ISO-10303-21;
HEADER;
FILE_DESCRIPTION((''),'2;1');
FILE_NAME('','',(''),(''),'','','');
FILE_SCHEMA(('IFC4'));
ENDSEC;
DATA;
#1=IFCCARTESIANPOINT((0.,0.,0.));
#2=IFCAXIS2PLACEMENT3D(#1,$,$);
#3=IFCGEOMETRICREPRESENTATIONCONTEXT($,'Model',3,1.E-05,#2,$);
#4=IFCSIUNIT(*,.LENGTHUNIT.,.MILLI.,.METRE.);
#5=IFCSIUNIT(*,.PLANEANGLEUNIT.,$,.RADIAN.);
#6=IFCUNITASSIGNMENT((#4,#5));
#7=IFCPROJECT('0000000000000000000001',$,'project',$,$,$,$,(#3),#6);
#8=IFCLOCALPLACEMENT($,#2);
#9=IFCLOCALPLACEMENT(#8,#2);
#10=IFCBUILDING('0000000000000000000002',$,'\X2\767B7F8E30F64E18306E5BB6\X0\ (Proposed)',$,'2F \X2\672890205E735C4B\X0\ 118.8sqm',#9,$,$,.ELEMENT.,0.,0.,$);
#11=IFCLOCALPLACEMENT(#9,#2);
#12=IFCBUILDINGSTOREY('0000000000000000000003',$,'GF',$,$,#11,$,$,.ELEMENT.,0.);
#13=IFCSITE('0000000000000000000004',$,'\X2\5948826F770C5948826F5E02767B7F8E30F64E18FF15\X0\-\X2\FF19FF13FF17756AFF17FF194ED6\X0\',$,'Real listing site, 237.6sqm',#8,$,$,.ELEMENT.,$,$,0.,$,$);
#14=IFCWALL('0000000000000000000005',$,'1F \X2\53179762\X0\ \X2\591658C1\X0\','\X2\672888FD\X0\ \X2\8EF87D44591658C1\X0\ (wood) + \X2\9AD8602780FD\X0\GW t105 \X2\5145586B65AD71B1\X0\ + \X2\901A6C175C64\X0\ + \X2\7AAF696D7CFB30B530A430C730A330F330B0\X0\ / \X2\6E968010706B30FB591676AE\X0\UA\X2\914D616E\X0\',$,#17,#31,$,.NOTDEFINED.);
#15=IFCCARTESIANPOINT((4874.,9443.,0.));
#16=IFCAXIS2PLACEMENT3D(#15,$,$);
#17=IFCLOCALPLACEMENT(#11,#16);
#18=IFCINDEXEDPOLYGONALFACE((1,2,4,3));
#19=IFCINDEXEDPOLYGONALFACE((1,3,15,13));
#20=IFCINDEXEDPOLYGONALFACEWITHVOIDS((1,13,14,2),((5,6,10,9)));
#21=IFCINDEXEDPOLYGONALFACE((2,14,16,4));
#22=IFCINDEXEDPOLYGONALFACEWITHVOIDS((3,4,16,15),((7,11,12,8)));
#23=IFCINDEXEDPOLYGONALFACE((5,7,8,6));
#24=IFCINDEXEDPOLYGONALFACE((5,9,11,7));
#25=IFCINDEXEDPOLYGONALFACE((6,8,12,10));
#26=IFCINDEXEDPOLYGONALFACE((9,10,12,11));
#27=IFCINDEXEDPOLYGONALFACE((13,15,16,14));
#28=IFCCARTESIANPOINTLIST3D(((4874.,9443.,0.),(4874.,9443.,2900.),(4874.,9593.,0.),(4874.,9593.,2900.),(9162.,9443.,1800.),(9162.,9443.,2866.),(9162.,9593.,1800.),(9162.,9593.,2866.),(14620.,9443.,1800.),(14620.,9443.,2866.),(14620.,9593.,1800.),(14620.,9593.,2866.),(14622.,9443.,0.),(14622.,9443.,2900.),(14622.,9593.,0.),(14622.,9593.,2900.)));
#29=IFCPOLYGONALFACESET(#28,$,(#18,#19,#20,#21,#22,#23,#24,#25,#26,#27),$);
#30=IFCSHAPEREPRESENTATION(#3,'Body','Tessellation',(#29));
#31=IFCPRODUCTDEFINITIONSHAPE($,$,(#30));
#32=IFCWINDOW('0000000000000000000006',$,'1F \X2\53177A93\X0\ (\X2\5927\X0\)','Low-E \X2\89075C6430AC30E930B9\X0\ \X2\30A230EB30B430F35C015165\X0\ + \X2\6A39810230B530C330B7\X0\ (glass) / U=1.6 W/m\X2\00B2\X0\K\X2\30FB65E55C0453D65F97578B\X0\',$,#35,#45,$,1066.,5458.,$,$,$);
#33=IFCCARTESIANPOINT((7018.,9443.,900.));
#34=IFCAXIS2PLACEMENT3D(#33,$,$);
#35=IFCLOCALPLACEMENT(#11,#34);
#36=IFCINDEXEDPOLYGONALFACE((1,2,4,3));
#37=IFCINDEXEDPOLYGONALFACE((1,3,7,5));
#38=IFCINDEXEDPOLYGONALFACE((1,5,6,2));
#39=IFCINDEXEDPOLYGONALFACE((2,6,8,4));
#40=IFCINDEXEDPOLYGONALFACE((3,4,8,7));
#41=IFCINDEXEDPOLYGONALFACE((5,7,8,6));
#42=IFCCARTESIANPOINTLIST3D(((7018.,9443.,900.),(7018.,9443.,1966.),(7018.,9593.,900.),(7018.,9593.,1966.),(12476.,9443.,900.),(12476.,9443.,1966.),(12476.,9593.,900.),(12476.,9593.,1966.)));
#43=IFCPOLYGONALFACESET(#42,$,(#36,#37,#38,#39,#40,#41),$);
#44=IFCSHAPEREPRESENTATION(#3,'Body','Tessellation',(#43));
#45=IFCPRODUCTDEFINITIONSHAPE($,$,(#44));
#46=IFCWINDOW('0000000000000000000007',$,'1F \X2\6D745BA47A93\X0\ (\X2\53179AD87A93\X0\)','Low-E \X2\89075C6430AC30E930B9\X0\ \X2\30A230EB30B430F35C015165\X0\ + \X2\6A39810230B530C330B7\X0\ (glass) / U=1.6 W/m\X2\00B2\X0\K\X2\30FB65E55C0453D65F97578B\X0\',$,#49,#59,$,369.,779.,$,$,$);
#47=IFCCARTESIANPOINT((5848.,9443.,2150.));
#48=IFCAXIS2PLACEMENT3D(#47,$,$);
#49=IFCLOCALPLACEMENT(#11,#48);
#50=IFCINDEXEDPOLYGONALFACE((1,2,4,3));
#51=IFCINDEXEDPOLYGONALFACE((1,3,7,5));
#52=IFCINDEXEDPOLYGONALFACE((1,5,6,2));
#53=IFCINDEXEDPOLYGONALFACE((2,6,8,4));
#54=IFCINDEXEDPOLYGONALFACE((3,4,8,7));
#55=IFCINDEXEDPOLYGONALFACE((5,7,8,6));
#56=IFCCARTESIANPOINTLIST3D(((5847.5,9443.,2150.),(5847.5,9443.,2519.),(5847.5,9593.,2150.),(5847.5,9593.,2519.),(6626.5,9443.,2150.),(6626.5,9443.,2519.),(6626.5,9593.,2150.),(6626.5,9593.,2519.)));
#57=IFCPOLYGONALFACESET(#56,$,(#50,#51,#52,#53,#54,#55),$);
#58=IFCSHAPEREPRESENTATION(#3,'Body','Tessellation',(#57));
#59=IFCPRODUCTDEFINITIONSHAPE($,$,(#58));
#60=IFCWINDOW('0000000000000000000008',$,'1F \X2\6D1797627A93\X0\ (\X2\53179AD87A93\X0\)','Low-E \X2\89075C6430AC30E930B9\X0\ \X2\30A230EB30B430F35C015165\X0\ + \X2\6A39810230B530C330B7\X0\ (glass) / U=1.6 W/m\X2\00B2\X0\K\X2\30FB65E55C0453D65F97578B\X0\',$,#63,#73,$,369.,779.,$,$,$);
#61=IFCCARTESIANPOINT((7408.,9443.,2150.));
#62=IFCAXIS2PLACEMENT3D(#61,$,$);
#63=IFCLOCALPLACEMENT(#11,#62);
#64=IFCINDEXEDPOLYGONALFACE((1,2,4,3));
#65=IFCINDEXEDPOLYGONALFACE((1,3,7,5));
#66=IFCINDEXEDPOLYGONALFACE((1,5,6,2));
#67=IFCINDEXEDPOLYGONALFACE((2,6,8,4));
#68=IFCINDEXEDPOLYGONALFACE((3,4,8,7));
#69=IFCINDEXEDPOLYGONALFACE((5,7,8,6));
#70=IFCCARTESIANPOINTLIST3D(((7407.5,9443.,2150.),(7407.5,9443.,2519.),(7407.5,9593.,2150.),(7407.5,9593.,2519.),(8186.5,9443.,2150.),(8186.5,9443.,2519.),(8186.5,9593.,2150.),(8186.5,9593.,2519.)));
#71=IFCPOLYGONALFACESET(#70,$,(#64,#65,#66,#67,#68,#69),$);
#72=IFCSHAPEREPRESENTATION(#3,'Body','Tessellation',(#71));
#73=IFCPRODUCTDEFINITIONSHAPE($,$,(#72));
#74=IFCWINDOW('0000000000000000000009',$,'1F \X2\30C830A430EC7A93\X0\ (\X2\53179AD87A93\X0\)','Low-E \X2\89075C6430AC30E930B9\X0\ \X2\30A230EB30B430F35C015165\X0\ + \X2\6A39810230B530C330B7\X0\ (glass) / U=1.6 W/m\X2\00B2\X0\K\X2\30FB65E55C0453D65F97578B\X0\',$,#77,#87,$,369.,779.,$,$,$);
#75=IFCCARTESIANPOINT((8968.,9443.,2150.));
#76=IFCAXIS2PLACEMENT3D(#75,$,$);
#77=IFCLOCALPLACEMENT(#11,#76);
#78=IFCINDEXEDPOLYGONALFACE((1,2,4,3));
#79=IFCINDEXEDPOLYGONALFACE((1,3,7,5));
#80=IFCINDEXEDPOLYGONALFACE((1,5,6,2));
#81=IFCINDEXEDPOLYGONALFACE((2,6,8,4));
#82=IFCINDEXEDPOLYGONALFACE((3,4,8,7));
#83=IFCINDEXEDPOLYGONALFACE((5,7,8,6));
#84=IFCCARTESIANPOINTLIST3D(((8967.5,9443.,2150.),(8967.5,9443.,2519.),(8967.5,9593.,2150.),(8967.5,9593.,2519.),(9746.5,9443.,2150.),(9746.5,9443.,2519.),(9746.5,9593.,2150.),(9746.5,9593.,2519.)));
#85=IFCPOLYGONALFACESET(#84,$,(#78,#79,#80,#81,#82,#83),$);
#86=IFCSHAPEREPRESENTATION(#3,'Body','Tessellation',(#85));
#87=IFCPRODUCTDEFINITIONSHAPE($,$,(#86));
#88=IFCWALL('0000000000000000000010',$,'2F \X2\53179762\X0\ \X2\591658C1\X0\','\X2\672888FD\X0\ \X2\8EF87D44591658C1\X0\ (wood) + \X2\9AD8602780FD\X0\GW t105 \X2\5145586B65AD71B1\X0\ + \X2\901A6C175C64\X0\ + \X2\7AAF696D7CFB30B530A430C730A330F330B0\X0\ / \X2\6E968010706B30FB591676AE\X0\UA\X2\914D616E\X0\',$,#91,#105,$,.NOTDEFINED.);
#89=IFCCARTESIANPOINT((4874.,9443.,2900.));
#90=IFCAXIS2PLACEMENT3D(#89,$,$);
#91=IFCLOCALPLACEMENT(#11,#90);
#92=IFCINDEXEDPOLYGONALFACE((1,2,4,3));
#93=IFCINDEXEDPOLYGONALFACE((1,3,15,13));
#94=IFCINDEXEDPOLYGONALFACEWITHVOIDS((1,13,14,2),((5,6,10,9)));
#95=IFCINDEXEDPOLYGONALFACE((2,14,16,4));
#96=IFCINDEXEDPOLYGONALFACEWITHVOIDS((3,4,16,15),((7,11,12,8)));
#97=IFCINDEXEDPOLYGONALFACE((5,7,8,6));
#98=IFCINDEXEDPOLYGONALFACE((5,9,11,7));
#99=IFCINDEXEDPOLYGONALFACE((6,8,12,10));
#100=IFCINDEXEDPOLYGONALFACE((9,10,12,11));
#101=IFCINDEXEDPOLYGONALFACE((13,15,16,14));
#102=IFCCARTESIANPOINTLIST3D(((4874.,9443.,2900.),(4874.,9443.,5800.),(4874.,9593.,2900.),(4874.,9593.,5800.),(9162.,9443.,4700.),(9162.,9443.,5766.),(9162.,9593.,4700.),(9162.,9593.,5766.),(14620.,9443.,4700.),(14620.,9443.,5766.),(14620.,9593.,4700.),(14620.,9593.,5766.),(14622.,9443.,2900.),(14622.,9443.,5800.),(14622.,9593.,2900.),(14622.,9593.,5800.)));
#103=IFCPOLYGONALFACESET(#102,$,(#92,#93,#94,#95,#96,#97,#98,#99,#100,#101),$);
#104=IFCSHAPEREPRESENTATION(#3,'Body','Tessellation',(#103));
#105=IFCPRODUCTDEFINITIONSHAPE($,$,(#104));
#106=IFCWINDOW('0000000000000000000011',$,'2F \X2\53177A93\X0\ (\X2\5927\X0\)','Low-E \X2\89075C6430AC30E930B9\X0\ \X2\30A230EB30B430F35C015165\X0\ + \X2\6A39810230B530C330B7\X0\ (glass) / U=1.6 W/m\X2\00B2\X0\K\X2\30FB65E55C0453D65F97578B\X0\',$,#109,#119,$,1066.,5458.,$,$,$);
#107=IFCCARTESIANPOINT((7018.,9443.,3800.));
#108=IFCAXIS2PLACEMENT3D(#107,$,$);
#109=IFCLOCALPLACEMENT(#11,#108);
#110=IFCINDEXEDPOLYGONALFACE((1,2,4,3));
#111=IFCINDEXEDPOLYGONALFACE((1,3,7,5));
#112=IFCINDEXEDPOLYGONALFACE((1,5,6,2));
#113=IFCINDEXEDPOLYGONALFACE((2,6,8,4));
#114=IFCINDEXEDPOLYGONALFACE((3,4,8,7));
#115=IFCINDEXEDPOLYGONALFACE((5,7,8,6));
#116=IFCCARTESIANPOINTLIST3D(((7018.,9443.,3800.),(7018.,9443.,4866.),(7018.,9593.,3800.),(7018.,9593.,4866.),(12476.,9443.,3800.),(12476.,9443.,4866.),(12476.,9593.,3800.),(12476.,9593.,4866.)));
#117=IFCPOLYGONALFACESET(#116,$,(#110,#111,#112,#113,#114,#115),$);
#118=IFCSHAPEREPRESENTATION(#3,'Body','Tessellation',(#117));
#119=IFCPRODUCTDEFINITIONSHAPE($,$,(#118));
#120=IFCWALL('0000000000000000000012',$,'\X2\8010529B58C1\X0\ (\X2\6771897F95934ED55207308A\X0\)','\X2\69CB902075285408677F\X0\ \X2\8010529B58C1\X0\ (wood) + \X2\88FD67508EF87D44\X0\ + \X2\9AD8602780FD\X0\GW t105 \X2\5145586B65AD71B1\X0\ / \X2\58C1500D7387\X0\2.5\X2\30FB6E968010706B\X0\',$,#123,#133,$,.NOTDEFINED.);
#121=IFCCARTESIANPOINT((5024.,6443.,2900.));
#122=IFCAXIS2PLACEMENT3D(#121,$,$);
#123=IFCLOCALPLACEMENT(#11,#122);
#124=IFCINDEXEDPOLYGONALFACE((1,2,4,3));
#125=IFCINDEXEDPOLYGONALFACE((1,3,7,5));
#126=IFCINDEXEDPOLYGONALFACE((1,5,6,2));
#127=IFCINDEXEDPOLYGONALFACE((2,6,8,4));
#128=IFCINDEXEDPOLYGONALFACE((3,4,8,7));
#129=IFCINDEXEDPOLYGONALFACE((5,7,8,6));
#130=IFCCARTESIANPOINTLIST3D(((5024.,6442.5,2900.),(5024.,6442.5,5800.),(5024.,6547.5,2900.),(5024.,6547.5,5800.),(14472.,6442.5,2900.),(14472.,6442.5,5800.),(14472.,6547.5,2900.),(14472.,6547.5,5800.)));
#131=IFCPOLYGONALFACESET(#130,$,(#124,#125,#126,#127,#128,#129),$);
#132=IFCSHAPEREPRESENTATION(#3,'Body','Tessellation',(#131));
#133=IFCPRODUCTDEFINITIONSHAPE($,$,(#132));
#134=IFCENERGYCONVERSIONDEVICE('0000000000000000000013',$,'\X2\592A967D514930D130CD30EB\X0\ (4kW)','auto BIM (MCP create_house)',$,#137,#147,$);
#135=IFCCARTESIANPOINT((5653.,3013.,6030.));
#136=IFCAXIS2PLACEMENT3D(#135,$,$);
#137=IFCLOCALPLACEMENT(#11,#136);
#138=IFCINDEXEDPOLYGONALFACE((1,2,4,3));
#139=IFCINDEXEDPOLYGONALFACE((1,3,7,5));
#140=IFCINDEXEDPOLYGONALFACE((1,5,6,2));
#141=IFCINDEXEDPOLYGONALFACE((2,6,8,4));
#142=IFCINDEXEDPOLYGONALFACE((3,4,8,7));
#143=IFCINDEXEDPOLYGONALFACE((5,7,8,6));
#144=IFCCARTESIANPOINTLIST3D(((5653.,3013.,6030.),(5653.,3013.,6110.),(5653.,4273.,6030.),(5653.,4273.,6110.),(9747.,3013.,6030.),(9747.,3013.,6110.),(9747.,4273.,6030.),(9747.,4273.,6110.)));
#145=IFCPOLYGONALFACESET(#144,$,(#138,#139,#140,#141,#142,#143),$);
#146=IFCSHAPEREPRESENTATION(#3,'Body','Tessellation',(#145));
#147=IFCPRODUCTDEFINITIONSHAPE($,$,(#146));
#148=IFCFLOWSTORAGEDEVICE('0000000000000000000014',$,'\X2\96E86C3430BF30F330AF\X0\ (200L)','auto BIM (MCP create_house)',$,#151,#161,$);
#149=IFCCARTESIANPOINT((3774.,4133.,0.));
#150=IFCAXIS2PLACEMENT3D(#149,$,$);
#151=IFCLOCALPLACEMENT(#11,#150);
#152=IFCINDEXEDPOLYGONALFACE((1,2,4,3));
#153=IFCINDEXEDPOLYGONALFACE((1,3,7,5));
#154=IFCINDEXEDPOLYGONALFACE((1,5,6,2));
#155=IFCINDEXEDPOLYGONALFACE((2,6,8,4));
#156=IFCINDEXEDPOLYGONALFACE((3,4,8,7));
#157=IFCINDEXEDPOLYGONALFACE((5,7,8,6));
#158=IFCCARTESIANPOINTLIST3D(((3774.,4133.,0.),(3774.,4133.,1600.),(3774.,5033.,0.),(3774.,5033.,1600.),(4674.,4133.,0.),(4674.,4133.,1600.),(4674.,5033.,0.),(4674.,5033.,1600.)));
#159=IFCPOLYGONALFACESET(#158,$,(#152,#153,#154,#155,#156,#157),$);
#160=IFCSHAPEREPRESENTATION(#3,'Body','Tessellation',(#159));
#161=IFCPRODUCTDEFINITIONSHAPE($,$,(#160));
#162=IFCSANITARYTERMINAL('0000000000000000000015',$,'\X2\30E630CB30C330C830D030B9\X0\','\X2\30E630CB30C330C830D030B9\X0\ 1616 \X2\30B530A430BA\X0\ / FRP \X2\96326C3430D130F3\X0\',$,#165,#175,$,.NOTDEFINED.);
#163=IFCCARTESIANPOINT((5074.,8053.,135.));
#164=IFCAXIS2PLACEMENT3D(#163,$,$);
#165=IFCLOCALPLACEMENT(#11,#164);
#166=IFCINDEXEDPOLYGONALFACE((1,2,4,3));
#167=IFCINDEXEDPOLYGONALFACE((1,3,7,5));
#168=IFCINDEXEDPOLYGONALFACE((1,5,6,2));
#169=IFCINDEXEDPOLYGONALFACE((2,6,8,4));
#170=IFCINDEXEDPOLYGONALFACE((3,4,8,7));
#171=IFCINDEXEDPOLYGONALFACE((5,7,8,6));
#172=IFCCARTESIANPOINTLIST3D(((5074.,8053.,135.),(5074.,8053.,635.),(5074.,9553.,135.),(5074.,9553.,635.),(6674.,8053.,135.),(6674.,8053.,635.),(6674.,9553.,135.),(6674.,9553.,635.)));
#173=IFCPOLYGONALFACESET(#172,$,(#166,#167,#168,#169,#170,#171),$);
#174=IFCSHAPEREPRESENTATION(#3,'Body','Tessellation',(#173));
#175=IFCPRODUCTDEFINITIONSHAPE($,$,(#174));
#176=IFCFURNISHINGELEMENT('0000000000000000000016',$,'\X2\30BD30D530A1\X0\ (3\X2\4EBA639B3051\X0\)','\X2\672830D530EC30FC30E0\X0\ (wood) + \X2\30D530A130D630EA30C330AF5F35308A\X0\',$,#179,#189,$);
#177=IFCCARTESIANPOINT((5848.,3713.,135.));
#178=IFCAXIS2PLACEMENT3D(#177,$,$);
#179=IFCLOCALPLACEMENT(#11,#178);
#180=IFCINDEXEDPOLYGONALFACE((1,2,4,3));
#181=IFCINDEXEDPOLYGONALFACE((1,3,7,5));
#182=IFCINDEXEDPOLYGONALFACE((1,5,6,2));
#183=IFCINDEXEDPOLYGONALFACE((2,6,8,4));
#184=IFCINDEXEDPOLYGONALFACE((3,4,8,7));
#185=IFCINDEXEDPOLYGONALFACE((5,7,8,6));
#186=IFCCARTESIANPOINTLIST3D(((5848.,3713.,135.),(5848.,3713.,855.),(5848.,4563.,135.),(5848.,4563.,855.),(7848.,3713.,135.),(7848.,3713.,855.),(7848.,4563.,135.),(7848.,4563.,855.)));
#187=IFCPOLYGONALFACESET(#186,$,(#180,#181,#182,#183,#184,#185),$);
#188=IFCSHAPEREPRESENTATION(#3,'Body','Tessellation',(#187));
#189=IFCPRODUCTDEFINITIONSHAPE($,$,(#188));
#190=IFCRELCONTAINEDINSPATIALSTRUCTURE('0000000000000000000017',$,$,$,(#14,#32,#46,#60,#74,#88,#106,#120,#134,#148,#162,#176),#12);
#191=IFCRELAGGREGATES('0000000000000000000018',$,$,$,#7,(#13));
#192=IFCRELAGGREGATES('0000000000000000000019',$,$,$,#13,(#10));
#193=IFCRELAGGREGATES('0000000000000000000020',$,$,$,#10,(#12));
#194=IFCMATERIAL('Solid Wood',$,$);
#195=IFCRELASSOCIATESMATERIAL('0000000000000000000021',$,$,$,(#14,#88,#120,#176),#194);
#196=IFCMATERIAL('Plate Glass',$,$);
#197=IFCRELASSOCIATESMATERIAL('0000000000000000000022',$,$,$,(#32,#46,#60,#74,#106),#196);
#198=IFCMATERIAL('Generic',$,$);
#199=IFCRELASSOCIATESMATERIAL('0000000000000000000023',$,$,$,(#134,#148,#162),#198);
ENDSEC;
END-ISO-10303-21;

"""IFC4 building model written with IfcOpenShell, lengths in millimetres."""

from ifc_helpers import new_model, si_unit, frame, frame_2d, origin, place, context, project, spatial, rectangle, extrude, material, element, fill, save


model = new_model("IFC4")

# Units and contexts
model_context = context("Model", 3, precision=1e-05, world=origin())
ifc_project = project(units=[si_unit("LENGTHUNIT", "METRE", prefix="MILLI"), si_unit("PLANEANGLEUNIT", "RADIAN")], contexts=[model_context])

# Site, building, storey
site_placement = place(None, origin())
site = spatial("IfcSite", under=ifc_project, at=site_placement, Name="奈良県奈良市登美ヶ丘５-９３７番７９他", ObjectType="Real listing site, 237.6sqm", CompositionType="ELEMENT", RefElevation=0.0)
building_placement = place(site_placement, origin())
building = spatial("IfcBuilding", under=site, at=building_placement, Name="登美ヶ丘の家 (Proposed)", ObjectType="2F 木造平屋 118.8sqm", CompositionType="ELEMENT", ElevationOfRefHeight=0.0, ElevationOfTerrain=0.0)
storey_placement = place(building_placement, origin())
storey = spatial("IfcBuildingStorey", under=building, at=storey_placement, Name="GF", CompositionType="ELEMENT", Elevation=0.0)

# Wall, openings, windows
ifc_material_1 = material(Name="Solid Wood")
wall_1_placement = place(storey_placement, frame((4874.0, 9443.0, 0.0)))
wall_1 = element("IfcWall", 1, at=wall_1_placement, inside=storey, material=ifc_material_1, Name="1F 北面 外壁", Description="木製 軸組外壁 (wood) + 高性能GW t105 充填断熱 + 通気層 + 窯業系サイディング / 準耐火・外皮UA配慮", PredefinedType="NOTDEFINED", context=model_context, shape_type="SweptSolid", body=[
    extrude(rectangle(XDim=9748.0, YDim=150.0, at=frame_2d((4874.0, 75.0))), frame((4874.0, 9443.0, 0.0)), (0.0, 0.0, 1.0), 2900.0),
])
opening_1_placement = place(storey_placement, frame((7018.0, 9443.0, 900.0)))
opening_1 = element("IfcOpeningElement", 2, at=opening_1_placement, cuts=wall_1, PredefinedType="NOTDEFINED", context=model_context, shape_type="SweptSolid", body=[
    extrude(rectangle(XDim=5458.0, YDim=150.0, at=frame_2d((2729.0, 75.0))), frame((7018.0, 9443.0, 900.0)), (0.0, 0.0, 1.0), 1066.0),
])
opening_2_placement = place(storey_placement, frame((5848.0, 9443.0, 2150.0)))
opening_2 = element("IfcOpeningElement", 3, at=opening_2_placement, cuts=wall_1, PredefinedType="NOTDEFINED", context=model_context, shape_type="SweptSolid", body=[
    extrude(rectangle(XDim=779.0, YDim=150.0, at=frame_2d((389.0, 75.0))), frame((5848.0, 9443.0, 2150.0)), (0.0, 0.0, 1.0), 369.0),
])
opening_3_placement = place(storey_placement, frame((7408.0, 9443.0, 2150.0)))
opening_3 = element("IfcOpeningElement", 4, at=opening_3_placement, cuts=wall_1, PredefinedType="NOTDEFINED", context=model_context, shape_type="SweptSolid", body=[
    extrude(rectangle(XDim=779.0, YDim=150.0, at=frame_2d((389.0, 75.0))), frame((7408.0, 9443.0, 2150.0)), (0.0, 0.0, 1.0), 369.0),
])
opening_4_placement = place(storey_placement, frame((8968.0, 9443.0, 2150.0)))
opening_4 = element("IfcOpeningElement", 5, at=opening_4_placement, cuts=wall_1, PredefinedType="NOTDEFINED", context=model_context, shape_type="SweptSolid", body=[
    extrude(rectangle(XDim=779.0, YDim=150.0, at=frame_2d((389.0, 75.0))), frame((8968.0, 9443.0, 2150.0)), (0.0, 0.0, 1.0), 369.0),
])
ifc_material_2 = material(Name="Plate Glass")
window_1_placement = place(storey_placement, frame((7018.0, 9443.0, 900.0)))
window_1 = element("IfcWindow", 6, at=window_1_placement, inside=storey, material=ifc_material_2, Name="1F 北窓 (大)", Description="Low-E 複層ガラス アルゴン封入 + 樹脂サッシ (glass) / U=1.6 W/m²K・日射取得型", OverallHeight=1066.0, OverallWidth=5458.0, context=model_context, shape_type="SweptSolid", body=[
    extrude(rectangle(XDim=5458.0, YDim=150.0, at=frame_2d((2729.0, 75.0))), frame((7018.0, 9443.0, 900.0)), (0.0, 0.0, 1.0), 1066.0),
])
fill(opening_1, window_1)
window_2_placement = place(storey_placement, frame((5848.0, 9443.0, 2150.0)))
window_2 = element("IfcWindow", 7, at=window_2_placement, inside=storey, material=ifc_material_2, Name="1F 浴室窓 (北高窓)", Description="Low-E 複層ガラス アルゴン封入 + 樹脂サッシ (glass) / U=1.6 W/m²K・日射取得型", OverallHeight=369.0, OverallWidth=779.0, context=model_context, shape_type="SweptSolid", body=[
    extrude(rectangle(XDim=779.0, YDim=150.0, at=frame_2d((389.0, 75.0))), frame((5848.0, 9443.0, 2150.0)), (0.0, 0.0, 1.0), 369.0),
])
fill(opening_2, window_2)
window_3_placement = place(storey_placement, frame((7408.0, 9443.0, 2150.0)))
window_3 = element("IfcWindow", 8, at=window_3_placement, inside=storey, material=ifc_material_2, Name="1F 洗面窓 (北高窓)", Description="Low-E 複層ガラス アルゴン封入 + 樹脂サッシ (glass) / U=1.6 W/m²K・日射取得型", OverallHeight=369.0, OverallWidth=779.0, context=model_context, shape_type="SweptSolid", body=[
    extrude(rectangle(XDim=779.0, YDim=150.0, at=frame_2d((389.0, 75.0))), frame((7408.0, 9443.0, 2150.0)), (0.0, 0.0, 1.0), 369.0),
])
fill(opening_3, window_3)
window_4_placement = place(storey_placement, frame((8968.0, 9443.0, 2150.0)))
window_4 = element("IfcWindow", 9, at=window_4_placement, inside=storey, material=ifc_material_2, Name="1F トイレ窓 (北高窓)", Description="Low-E 複層ガラス アルゴン封入 + 樹脂サッシ (glass) / U=1.6 W/m²K・日射取得型", OverallHeight=369.0, OverallWidth=779.0, context=model_context, shape_type="SweptSolid", body=[
    extrude(rectangle(XDim=779.0, YDim=150.0, at=frame_2d((389.0, 75.0))), frame((8968.0, 9443.0, 2150.0)), (0.0, 0.0, 1.0), 369.0),
])
fill(opening_4, window_4)

# Wall, opening, window
wall_2_placement = place(storey_placement, frame((4874.0, 9443.0, 2900.0)))
wall_2 = element("IfcWall", 10, at=wall_2_placement, inside=storey, material=ifc_material_1, Name="2F 北面 外壁", Description="木製 軸組外壁 (wood) + 高性能GW t105 充填断熱 + 通気層 + 窯業系サイディング / 準耐火・外皮UA配慮", PredefinedType="NOTDEFINED", context=model_context, shape_type="SweptSolid", body=[
    extrude(rectangle(XDim=9748.0, YDim=150.0, at=frame_2d((4874.0, 75.0))), frame((4874.0, 9443.0, 2900.0)), (0.0, 0.0, 1.0), 2900.0),
])
opening_5_placement = place(storey_placement, frame((7018.0, 9443.0, 3800.0)))
opening_5 = element("IfcOpeningElement", 11, at=opening_5_placement, cuts=wall_2, PredefinedType="NOTDEFINED", context=model_context, shape_type="SweptSolid", body=[
    extrude(rectangle(XDim=5458.0, YDim=150.0, at=frame_2d((2729.0, 75.0))), frame((7018.0, 9443.0, 3800.0)), (0.0, 0.0, 1.0), 1066.0),
])
window_5_placement = place(storey_placement, frame((7018.0, 9443.0, 3800.0)))
window_5 = element("IfcWindow", 12, at=window_5_placement, inside=storey, material=ifc_material_2, Name="2F 北窓 (大)", Description="Low-E 複層ガラス アルゴン封入 + 樹脂サッシ (glass) / U=1.6 W/m²K・日射取得型", OverallHeight=1066.0, OverallWidth=5458.0, context=model_context, shape_type="SweptSolid", body=[
    extrude(rectangle(XDim=5458.0, YDim=150.0, at=frame_2d((2729.0, 75.0))), frame((7018.0, 9443.0, 3800.0)), (0.0, 0.0, 1.0), 1066.0),
])
fill(opening_5, window_5)

# Wall
wall_3_placement = place(storey_placement, frame((5024.0, 6443.0, 2900.0)))
element("IfcWall", 13, at=wall_3_placement, inside=storey, material=ifc_material_1, Name="耐力壁 (東西間仕切り)", Description="構造用合板 耐力壁 (wood) + 製材軸組 + 高性能GW t105 充填断熱 / 壁倍率2.5・準耐火", PredefinedType="NOTDEFINED", context=model_context, shape_type="SweptSolid", body=[
    extrude(rectangle(XDim=9448.0, YDim=105.0, at=frame_2d((4724.0, 52.0))), frame((5024.0, 6443.0, 2900.0)), (0.0, 0.0, 1.0), 2900.0),
])

# Energy conversion device
ifc_material_3 = material(Name="Generic")
energy_conversion_device_placement = place(storey_placement, frame((5653.0, 3013.0, 6030.0)))
element("IfcEnergyConversionDevice", 14, at=energy_conversion_device_placement, inside=storey, material=ifc_material_3, Name="太陽光パネル (4kW)", Description="auto BIM (MCP create_house)", context=model_context, shape_type="SweptSolid", body=[
    extrude(rectangle(XDim=4094.0, YDim=1260.0, at=frame_2d((2047.0, 630.0))), frame((5653.0, 3013.0, 6030.0)), (0.0, 0.0, 1.0), 80.0),
])

# Flow storage device
flow_storage_device_placement = place(storey_placement, frame((3774.0, 4133.0, 0.0)))
element("IfcFlowStorageDevice", 15, at=flow_storage_device_placement, inside=storey, material=ifc_material_3, Name="雨水タンク (200L)", Description="auto BIM (MCP create_house)", context=model_context, shape_type="SweptSolid", body=[
    extrude(rectangle(XDim=900.0, YDim=900.0, at=frame_2d((450.0, 450.0))), frame((3774.0, 4133.0, 0.0)), (0.0, 0.0, 1.0), 1600.0),
])

# Sanitary terminal
sanitary_terminal_placement = place(storey_placement, frame((5074.0, 8053.0, 135.0)))
element("IfcSanitaryTerminal", 16, at=sanitary_terminal_placement, inside=storey, material=ifc_material_3, Name="ユニットバス", Description="ユニットバス 1616 サイズ / FRP 防水パン", PredefinedType="NOTDEFINED", context=model_context, shape_type="SweptSolid", body=[
    extrude(rectangle(XDim=1600.0, YDim=1500.0, at=frame_2d((800.0, 750.0))), frame((5074.0, 8053.0, 135.0)), (0.0, 0.0, 1.0), 500.0),
])

# Furnishing element
furnishing_1_placement = place(storey_placement, frame((5848.0, 3713.0, 135.0)))
element("IfcFurnishingElement", 17, at=furnishing_1_placement, inside=storey, material=ifc_material_1, Name="ソファ (3人掛け)", Description="木フレーム (wood) + ファブリック張り", context=model_context, shape_type="SweptSolid", body=[
    extrude(rectangle(XDim=2000.0, YDim=850.0, at=frame_2d((1000.0, 425.0))), frame((5848.0, 3713.0, 135.0)), (0.0, 0.0, 1.0), 720.0),
])

save(model, "model.ifc")
